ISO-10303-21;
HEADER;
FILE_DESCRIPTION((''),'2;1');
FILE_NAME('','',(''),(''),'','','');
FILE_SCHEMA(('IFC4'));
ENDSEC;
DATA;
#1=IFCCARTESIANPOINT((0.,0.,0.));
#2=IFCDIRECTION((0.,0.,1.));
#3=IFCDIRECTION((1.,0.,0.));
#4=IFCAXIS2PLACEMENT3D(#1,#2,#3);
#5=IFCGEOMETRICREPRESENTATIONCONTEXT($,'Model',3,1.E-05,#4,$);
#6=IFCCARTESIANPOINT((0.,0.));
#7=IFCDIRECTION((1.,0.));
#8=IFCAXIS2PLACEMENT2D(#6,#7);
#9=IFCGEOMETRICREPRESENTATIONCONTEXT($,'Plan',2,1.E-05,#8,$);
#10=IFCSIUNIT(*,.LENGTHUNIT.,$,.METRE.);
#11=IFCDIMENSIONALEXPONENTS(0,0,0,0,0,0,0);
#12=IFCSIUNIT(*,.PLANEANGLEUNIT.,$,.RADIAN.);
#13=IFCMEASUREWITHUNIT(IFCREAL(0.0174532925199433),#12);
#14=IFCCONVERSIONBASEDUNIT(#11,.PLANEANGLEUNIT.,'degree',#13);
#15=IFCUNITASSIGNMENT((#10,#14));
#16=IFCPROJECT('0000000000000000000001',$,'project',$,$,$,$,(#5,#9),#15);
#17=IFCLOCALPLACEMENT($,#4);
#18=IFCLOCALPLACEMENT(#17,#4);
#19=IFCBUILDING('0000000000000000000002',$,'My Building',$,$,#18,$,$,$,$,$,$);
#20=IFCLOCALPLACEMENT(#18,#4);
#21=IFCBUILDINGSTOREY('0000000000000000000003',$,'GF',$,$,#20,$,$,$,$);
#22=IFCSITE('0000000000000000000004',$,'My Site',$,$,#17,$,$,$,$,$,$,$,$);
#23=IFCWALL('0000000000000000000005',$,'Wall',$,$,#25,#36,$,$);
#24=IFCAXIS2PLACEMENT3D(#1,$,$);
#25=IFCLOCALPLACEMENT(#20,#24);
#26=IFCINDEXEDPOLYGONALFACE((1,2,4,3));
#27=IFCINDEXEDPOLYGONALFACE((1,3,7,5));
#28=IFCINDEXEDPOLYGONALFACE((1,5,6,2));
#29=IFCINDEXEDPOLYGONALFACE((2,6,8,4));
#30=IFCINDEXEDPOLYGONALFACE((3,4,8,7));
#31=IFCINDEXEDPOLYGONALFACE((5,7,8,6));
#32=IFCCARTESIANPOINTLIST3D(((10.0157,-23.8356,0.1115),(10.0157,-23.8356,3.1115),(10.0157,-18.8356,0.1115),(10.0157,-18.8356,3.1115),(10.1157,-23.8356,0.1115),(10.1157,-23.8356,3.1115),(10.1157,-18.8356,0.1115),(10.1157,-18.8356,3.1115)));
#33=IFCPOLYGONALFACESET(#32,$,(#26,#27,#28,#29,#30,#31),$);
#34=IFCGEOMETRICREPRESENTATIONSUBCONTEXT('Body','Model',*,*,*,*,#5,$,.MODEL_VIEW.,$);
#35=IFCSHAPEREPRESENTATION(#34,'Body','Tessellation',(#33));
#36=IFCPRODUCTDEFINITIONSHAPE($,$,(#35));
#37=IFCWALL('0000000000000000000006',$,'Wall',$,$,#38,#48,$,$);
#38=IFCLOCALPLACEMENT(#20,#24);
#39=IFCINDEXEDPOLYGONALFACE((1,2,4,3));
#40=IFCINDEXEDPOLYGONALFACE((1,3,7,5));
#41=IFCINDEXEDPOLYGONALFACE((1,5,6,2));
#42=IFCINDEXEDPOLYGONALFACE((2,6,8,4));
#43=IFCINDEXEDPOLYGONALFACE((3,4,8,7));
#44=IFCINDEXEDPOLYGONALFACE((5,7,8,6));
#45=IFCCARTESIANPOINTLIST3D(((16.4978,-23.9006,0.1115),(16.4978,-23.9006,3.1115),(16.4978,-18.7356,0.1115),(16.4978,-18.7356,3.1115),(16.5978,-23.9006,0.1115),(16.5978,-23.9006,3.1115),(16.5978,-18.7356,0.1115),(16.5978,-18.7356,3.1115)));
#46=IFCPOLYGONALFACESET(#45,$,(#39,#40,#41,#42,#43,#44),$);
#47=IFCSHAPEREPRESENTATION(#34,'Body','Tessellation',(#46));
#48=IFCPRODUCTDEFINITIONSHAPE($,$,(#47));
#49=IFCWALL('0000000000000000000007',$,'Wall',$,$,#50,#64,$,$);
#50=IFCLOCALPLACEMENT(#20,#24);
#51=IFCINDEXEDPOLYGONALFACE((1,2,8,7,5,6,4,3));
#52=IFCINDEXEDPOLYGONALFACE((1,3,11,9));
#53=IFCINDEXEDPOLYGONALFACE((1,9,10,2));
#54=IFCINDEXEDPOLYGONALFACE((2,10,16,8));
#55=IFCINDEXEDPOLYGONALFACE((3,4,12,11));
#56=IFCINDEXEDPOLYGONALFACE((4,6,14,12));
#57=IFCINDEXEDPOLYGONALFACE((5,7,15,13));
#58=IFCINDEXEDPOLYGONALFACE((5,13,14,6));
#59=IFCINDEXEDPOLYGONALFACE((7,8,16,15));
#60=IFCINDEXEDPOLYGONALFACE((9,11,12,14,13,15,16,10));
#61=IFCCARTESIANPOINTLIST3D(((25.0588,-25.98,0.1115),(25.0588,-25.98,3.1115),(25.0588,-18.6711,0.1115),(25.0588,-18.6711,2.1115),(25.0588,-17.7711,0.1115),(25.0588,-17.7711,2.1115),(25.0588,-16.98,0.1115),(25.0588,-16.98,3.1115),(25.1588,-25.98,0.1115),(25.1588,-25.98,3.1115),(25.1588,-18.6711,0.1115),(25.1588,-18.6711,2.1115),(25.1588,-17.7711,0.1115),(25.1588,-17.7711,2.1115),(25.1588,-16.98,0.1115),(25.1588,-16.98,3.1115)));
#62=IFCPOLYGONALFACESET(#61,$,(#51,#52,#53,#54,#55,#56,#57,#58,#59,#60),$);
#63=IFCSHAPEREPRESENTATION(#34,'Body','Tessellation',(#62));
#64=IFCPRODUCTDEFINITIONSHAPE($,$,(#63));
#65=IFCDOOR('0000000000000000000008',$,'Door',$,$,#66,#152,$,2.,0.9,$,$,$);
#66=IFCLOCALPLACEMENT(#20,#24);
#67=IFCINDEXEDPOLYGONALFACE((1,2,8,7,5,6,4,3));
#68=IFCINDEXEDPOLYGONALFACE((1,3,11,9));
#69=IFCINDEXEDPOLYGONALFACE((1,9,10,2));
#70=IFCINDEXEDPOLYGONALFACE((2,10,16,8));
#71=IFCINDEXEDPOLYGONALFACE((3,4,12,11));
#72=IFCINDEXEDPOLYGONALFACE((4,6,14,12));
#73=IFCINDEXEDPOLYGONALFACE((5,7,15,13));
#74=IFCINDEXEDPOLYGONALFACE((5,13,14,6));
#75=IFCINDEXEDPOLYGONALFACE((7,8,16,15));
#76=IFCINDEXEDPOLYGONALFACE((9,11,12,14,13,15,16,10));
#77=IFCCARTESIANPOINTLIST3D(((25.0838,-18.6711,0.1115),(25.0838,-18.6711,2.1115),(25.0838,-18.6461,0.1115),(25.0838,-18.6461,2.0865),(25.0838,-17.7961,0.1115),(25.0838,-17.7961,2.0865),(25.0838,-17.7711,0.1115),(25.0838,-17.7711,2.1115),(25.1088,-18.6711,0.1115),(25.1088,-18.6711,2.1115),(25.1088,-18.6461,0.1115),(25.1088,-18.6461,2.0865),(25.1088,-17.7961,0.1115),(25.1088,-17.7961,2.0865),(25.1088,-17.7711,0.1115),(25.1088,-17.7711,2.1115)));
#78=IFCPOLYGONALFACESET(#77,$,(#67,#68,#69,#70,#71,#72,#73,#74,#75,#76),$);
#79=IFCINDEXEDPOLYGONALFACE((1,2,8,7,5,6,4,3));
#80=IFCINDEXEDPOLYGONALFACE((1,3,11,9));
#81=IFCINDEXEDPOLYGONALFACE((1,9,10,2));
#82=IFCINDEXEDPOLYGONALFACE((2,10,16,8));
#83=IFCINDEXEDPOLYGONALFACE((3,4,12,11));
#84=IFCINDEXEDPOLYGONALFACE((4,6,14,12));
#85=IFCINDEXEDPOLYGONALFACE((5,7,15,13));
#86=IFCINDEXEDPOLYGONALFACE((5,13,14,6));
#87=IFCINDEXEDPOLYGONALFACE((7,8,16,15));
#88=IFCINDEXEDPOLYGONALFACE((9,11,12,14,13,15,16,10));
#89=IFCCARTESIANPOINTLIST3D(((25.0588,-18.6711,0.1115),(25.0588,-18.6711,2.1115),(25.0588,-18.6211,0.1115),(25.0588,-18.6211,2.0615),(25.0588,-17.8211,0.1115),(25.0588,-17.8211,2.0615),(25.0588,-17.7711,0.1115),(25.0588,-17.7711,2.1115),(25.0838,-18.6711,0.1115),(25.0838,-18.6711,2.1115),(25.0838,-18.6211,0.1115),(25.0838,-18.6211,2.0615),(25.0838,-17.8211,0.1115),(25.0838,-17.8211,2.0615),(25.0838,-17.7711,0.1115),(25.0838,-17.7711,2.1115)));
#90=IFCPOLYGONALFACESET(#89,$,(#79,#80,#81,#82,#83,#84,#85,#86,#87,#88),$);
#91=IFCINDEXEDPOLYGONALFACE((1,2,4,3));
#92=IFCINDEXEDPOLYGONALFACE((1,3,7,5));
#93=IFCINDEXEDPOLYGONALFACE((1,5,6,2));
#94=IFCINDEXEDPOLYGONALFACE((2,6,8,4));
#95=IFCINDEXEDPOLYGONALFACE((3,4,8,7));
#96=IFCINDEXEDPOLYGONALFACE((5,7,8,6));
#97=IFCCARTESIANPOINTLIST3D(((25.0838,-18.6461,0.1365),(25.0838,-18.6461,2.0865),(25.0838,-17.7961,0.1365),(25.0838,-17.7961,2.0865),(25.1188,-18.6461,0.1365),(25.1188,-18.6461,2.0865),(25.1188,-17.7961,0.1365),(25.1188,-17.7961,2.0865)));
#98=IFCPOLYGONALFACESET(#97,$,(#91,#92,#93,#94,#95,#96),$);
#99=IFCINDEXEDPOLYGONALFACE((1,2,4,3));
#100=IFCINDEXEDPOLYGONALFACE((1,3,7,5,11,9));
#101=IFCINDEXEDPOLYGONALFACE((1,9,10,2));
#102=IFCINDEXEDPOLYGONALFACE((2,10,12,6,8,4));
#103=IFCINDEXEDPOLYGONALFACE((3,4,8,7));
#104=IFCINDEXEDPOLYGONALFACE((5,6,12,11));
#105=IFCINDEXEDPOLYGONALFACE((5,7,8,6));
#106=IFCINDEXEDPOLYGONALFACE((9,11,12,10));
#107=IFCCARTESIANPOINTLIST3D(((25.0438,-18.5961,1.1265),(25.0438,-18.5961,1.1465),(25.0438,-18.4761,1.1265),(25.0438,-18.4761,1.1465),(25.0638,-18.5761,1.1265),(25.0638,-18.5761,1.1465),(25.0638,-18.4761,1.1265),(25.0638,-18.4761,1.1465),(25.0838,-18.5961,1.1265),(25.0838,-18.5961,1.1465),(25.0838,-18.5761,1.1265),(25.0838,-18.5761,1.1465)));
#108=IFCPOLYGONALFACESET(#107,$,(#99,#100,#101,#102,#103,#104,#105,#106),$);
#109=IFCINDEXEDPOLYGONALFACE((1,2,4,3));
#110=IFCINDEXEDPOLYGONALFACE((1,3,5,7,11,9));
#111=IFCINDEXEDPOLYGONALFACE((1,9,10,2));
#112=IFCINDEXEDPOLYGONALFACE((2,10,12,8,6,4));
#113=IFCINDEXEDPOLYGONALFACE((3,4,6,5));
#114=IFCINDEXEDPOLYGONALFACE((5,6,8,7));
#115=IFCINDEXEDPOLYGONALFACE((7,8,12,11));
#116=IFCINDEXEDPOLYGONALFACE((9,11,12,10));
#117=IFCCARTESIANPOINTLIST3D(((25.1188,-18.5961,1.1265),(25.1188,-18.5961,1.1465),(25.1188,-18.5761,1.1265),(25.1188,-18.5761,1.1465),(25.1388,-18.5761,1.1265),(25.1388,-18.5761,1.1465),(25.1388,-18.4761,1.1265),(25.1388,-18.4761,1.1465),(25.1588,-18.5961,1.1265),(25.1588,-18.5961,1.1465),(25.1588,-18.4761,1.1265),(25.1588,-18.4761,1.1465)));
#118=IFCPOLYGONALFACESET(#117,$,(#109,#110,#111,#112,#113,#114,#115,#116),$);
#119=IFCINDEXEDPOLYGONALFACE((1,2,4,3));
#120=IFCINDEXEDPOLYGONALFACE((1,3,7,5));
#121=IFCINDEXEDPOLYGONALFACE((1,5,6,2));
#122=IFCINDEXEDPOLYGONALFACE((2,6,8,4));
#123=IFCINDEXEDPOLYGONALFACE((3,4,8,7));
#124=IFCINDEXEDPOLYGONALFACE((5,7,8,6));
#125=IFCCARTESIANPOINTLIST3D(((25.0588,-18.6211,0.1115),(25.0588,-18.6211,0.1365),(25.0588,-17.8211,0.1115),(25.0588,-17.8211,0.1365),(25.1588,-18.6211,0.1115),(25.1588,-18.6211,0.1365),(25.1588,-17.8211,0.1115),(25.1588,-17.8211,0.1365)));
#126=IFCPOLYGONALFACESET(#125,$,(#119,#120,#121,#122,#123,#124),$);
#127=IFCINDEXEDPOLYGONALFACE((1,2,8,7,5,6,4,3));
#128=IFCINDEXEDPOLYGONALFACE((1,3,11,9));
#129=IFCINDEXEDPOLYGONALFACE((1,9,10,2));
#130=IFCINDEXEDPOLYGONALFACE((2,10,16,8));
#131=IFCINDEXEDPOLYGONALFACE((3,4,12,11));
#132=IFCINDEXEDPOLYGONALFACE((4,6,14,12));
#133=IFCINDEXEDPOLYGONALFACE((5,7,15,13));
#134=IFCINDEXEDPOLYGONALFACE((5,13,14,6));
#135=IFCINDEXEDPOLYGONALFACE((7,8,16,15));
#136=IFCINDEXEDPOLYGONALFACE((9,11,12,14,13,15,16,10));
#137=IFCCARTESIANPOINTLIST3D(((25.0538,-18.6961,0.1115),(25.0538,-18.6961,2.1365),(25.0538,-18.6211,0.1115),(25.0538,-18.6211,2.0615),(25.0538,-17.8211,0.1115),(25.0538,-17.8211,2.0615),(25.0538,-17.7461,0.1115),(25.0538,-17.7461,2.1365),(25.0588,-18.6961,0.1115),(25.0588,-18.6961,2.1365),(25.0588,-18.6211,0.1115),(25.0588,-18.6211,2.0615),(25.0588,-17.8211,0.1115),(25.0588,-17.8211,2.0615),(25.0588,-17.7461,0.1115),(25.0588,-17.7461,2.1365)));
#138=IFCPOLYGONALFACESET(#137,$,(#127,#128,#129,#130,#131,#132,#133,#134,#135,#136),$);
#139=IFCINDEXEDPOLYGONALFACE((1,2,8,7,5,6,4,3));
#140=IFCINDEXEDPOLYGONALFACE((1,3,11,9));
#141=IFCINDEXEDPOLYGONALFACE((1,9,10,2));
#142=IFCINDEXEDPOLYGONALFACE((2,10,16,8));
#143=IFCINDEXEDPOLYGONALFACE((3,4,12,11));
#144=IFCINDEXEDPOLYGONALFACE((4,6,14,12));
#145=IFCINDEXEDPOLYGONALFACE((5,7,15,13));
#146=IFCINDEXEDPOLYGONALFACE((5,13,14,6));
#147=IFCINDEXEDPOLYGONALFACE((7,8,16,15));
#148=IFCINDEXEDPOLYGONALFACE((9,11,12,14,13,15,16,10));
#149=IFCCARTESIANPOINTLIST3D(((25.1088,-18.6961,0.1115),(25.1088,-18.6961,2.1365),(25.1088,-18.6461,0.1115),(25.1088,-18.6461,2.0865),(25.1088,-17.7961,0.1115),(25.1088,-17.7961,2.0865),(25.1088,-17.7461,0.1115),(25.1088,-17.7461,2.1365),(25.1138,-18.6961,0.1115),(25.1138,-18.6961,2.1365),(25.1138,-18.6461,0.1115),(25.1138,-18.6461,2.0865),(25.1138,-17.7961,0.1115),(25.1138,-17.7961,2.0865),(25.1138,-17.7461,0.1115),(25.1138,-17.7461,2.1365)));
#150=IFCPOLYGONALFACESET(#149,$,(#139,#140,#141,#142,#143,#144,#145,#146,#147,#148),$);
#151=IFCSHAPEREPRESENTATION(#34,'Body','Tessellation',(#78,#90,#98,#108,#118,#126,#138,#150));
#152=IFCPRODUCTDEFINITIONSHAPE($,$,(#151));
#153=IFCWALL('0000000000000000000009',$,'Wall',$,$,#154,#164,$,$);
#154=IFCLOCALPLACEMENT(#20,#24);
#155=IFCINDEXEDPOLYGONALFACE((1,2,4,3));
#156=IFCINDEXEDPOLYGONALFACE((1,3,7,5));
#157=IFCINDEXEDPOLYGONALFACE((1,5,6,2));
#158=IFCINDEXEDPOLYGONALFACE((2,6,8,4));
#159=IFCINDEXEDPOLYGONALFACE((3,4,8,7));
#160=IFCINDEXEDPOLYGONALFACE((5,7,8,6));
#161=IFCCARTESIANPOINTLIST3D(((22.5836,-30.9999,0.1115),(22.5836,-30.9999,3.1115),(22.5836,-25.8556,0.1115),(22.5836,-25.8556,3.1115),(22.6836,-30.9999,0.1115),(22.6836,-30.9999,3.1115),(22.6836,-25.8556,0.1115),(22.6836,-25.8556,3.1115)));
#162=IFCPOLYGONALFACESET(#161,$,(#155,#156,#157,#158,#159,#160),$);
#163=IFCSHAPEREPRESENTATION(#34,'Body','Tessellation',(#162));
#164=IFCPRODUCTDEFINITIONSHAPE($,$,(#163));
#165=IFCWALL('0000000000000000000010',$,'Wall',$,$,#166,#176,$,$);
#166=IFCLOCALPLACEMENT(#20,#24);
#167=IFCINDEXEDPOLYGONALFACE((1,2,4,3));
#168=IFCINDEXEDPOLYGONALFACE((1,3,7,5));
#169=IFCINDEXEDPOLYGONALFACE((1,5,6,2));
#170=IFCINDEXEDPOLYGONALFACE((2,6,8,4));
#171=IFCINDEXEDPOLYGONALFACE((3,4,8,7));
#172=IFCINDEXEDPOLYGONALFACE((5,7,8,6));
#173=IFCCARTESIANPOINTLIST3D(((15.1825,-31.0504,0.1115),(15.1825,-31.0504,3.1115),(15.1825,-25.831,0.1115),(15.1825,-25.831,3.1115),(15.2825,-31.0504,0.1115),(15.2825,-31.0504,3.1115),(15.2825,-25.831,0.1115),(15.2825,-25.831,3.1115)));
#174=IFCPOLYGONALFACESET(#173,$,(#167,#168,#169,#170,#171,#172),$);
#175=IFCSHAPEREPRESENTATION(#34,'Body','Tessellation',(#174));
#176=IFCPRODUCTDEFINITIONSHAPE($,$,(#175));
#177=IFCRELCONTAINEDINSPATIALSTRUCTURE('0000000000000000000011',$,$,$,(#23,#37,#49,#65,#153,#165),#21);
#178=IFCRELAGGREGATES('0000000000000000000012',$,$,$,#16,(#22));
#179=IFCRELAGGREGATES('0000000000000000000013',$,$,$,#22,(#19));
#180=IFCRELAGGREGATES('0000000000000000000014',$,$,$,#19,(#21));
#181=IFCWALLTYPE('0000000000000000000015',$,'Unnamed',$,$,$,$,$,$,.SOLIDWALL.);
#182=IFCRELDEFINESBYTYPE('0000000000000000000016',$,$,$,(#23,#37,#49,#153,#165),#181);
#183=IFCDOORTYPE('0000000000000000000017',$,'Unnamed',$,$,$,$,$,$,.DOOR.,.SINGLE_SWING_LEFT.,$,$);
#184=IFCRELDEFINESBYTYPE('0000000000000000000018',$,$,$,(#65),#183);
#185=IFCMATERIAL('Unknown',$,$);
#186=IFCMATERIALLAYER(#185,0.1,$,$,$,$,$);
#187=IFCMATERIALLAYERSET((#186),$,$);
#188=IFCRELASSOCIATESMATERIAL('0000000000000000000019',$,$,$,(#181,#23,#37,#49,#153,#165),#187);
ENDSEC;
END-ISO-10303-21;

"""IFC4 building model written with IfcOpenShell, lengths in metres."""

from ifc_helpers import new_model, entity, si_unit, converted_unit, frame, origin_with_axes, origin_2d_with_axis, place, context, subcontext, project, spatial, line, indexed_curve, outline, extrude, shape, source, transform, mapped, material, layer, layer_set, layer_usage, type_object, type_shapes, element, fill, save


model = new_model("IFC4")

# Units and contexts
model_context = context("Model", 3, precision=1e-05, world=origin_with_axes())
plan_context = context("Plan", 2, precision=1e-05, world=origin_2d_with_axis())
body_context_1 = subcontext(model_context, "Body", "Model", "MODEL_VIEW")
body_context_2 = subcontext(plan_context, "Body", "Plan", "PLAN_VIEW")
ifc_project = project(units=[si_unit("LENGTHUNIT", "METRE"), converted_unit("PLANEANGLEUNIT", "degree", entity("IfcReal", 0.0174532925199433), si_unit("PLANEANGLEUNIT", "RADIAN"), dimensions=[0, 0, 0, 0, 0, 0, 0])], contexts=[model_context, plan_context])

# Site, building, storey
site_placement = place(None, origin_with_axes())
site = spatial("IfcSite", under=ifc_project, at=site_placement, Name="My Site")
building_placement = place(site_placement, origin_with_axes())
building = spatial("IfcBuilding", under=site, at=building_placement, Name="My Building")
storey_placement = place(building_placement, origin_with_axes())
storey = spatial("IfcBuildingStorey", under=building, at=storey_placement, Name="GF")

# Shared definitions
ifc_material = material(Name="Unknown")
ifc_layer = layer(ifc_material, 0.1)
ifc_layer_set = layer_set([ifc_layer])
wall_type = type_object("IfcWallType", Name="Unnamed", PredefinedType="SOLIDWALL", material=ifc_layer_set)

# Shared definitions
shared_shape_1 = source(origin_with_axes(), body_context_1, "Body", "SweptSolid", [
    extrude(outline(indexed_curve([(0.0, 0.0), (0.9, 0.0), (0.9, 2.0), (0.0, 2.0)], segments=[line(1, 2, 3, 4, 1)])), frame((0.0, -0.6, 0.0), z_axis=(0.0, -1.0, 0.0), x_axis=(1.0, 0.0, 0.0)), (0.0, 0.0, -1.0), 1.2),
])
door_type = type_object("IfcDoorType", Name="Unnamed", OperationType="SINGLE_SWING_LEFT", PredefinedType="DOOR")
shared_shape_2 = source(origin_with_axes(), body_context_1, "Body", "SweptSolid", [
    extrude(outline(indexed_curve([(0.0, 0.0), (0.0, 2.0), (0.9, 2.0), (0.9, 0.0), (0.875, 0.0), (0.875, 1.975), (0.025, 1.975), (0.025, 0.0)], segments=[line(1, 2, 3, 4, 5, 6, 7, 8, 1)])), frame((0.0, 0.025, 0.0), z_axis=(0.0, -1.0, 0.0), x_axis=(1.0, 0.0, 0.0)), (0.0, 0.0, -1.0), 0.025),
    extrude(outline(indexed_curve([(0.0, 0.0), (0.0, 2.0), (0.9, 2.0), (0.9, 0.0), (0.85, 0.0), (0.85, 1.95), (0.05, 1.95), (0.05, 0.0)], segments=[line(1, 2, 3, 4, 5, 6, 7, 8, 1)])), frame((0.0, 0.0, 0.0), z_axis=(0.0, -1.0, 0.0), x_axis=(1.0, 0.0, 0.0)), (0.0, 0.0, -1.0), 0.025),
    extrude(outline(indexed_curve([(0.0, 0.0), (0.85, 0.0), (0.85, 0.035), (0.0, 0.035)], segments=[line(1, 2, 3, 4, 1)])), frame((0.025, 0.025, 0.025), z_axis=(0.0, 0.0, 1.0), x_axis=(1.0, 0.0, 0.0)), (0.0, 0.0, 1.0), 1.95),
    extrude(outline(indexed_curve([(0.0, 0.0), (0.0, -0.04), (-0.12, -0.04), (-0.12, -0.02), (-0.02, -0.02), (-0.02, 0.0)], segments=[line(1, 2, 3, 4, 5, 6, 1)])), frame((0.825, 0.025, 1.015), z_axis=(0.0, 0.0, 1.0), x_axis=(1.0, 0.0, 0.0)), (0.0, 0.0, 1.0), 0.02),
    extrude(outline(indexed_curve([(0.0, 0.0), (0.0, 0.04), (-0.12, 0.04), (-0.12, 0.02), (-0.02, 0.02), (-0.02, 0.0)], segments=[line(1, 2, 3, 4, 5, 6, 1)])), frame((0.825, 0.06, 1.015), z_axis=(0.0, 0.0, 1.0), x_axis=(1.0, 0.0, 0.0)), (0.0, 0.0, 1.0), 0.02),
    extrude(outline(indexed_curve([(0.0, 0.0), (0.8, 0.0), (0.8, 0.1), (0.0, 0.1)], segments=[line(1, 2, 3, 4, 1)])), frame((0.05, 0.0, 0.0), z_axis=(0.0, 0.0, 1.0), x_axis=(1.0, 0.0, 0.0)), (0.0, 0.0, 1.0), 0.025),
    extrude(outline(indexed_curve([(0.0, 0.0), (0.0, 2.025), (0.95, 2.025), (0.95, 0.0), (0.875, 0.0), (0.875, 1.95), (0.075, 1.95), (0.075, 0.0)], segments=[line(1, 2, 3, 4, 5, 6, 7, 8, 1)])), frame((-0.025, -0.005, 0.0), z_axis=(0.0, -1.0, 0.0), x_axis=(1.0, 0.0, 0.0)), (0.0, 0.0, -1.0), 0.005),
    extrude(outline(indexed_curve([(0.0, 0.0), (0.0, 2.025), (0.95, 2.025), (0.95, 0.0), (0.9, 0.0), (0.9, 1.975), (0.05, 1.975), (0.05, 0.0)], segments=[line(1, 2, 3, 4, 5, 6, 7, 8, 1)])), frame((-0.025, 0.05, 0.0), z_axis=(0.0, -1.0, 0.0), x_axis=(1.0, 0.0, 0.0)), (0.0, 0.0, -1.0), 0.005),
])
shared_shape_3 = source(origin_with_axes(), body_context_2, "Body", "Curve2D", [
    entity("IfcIndexedPolyCurve", entity("IfcCartesianPointList2D", [[0.0, 0.0], [0.0, 0.05], [0.025, 0.05], [0.025, 0.025], [0.05, 0.025], [0.05, 0.0]]), [entity("IfcLineIndex", [1, 2, 3, 4, 5, 6, 1])]),
    entity("IfcIndexedPolyCurve", entity("IfcCartesianPointList2D", [[0.9, 0.0], [0.9, 0.05], [0.875, 0.05], [0.875, 0.025], [0.85, 0.025], [0.85, 0.0]]), [entity("IfcLineIndex", [1, 2, 3, 4, 5, 6, 1])]),
    entity("IfcTrimmedCurve", entity("IfcEllipse", entity("IfcAxis2Placement2D", entity("IfcCartesianPoint", [0.06, 0.05]), entity("IfcDirection", [1.0, 0.0])), 0.815, 0.85), [entity("IfcCartesianPoint", [0.875, 0.05])], [entity("IfcCartesianPoint", [0.06, 0.9])], True, "CARTESIAN"),
    entity("IfcIndexedPolyCurve", entity("IfcCartesianPointList2D", [[0.025, 0.05], [0.06, 0.05], [0.06, 0.9], [0.025, 0.9]]), [entity("IfcLineIndex", [1, 2, 3, 4, 1])]),
])
type_shapes(door_type, [shared_shape_2, shared_shape_3])

# Walls
ifc_layer_usage_1 = layer_usage(ifc_layer_set, "AXIS2", "POSITIVE", 0.0)
wall_1_placement = place(storey_placement, frame((10.0157, -18.8356, 0.1115), z_axis=(0.0, 0.0, 1.0), x_axis=(0.0, -1.0, 0.0)))
element("IfcWall", 1, at=wall_1_placement, inside=storey, type_object=wall_type, material=ifc_layer_usage_1, Name="Wall", context=body_context_1, shape_type="SweptSolid", body=[
    extrude(outline(indexed_curve([(0.0, 0.0), (0.0, 0.1), (5.0, 0.1), (5.0, 0.0)], segments=[line(1, 2, 3, 4, 1)])), origin_with_axes(), (0.0, 0.0, 1.0), 3.0),
])
ifc_layer_usage_2 = layer_usage(ifc_layer_set, "AXIS2", "POSITIVE", 0.0)
wall_2_placement = place(storey_placement, frame((16.4978, -18.7356, 0.1115), z_axis=(0.0, 0.0, 1.0), x_axis=(0.0, -1.0, 0.0)))
element("IfcWall", 2, at=wall_2_placement, inside=storey, type_object=wall_type, material=ifc_layer_usage_2, Name="Wall", context=body_context_1, shape_type="SweptSolid", body=[
    extrude(outline(indexed_curve([(0.0, 0.0), (0.0, 0.1), (5.1651, 0.1), (5.1651, 0.0)], segments=[line(1, 2, 3, 4, 1)])), origin_with_axes(), (0.0, 0.0, 1.0), 3.0),
])

# Wall, opening, door
ifc_layer_usage_3 = layer_usage(ifc_layer_set, "AXIS2", "POSITIVE", 0.0)
wall_3_placement = place(storey_placement, frame((25.0588, -16.98, 0.1115), z_axis=(0.0, 0.0, 1.0), x_axis=(0.0, -1.0, 0.0)))
wall_3 = element("IfcWall", 3, at=wall_3_placement, inside=storey, type_object=wall_type, material=ifc_layer_usage_3, Name="Wall", context=body_context_1, shape_type="SweptSolid", body=[
    extrude(outline(indexed_curve([(0.0, 0.0), (0.0, 0.1), (9.0, 0.1), (9.0, 0.0)], segments=[line(1, 2, 3, 4, 1)])), origin_with_axes(), (0.0, 0.0, 1.0), 3.0),
])
opening_1_placement = place(wall_3_placement, frame((0.7911, 0.0, 0.0), z_axis=(0.0, 0.0, 1.0), x_axis=(1.0, 0.0, 0.0)))
opening_1 = element("IfcOpeningElement", 4, at=opening_1_placement, cuts=wall_3, PredefinedType="OPENING", context=body_context_1, shape_type="MappedRepresentation", body=[
    mapped(shared_shape_1, transform((0.0, 0.0, 0.0), x_axis=(1.0, 0.0, 0.0), y_axis=(0.0, 1.0, 0.0), z_axis=(0.0, 0.0, 1.0), scale=1.0)),
])
door_1_placement = place(opening_1_placement, frame((0.0, 0.0, 0.0), z_axis=(0.0, 0.0, 1.0), x_axis=(1.0, 0.0, 0.0)))
door_1 = element("IfcDoor", 5, at=door_1_placement, inside=storey, type_object=door_type, Name="Door", OverallHeight=2.0, OverallWidth=0.9, shapes=[
    shape(body_context_1, "Body", "MappedRepresentation", [mapped(shared_shape_2, transform((0.0, 0.0, 0.0), x_axis=(1.0, 0.0, 0.0), y_axis=(0.0, 1.0, 0.0), z_axis=(0.0, 0.0, 1.0), scale=1.0))]),
    shape(body_context_2, "Body", "MappedRepresentation", [mapped(shared_shape_3, transform((0.0, 0.0, 0.0), x_axis=(1.0, 0.0, 0.0), y_axis=(0.0, 1.0, 0.0), z_axis=(0.0, 0.0, 1.0), scale=1.0))]),
])
fill(opening_1, door_1)

# Walls
ifc_layer_usage_4 = layer_usage(ifc_layer_set, "AXIS2", "POSITIVE", 0.0)
wall_4_placement = place(storey_placement, frame((22.5836, -25.8556, 0.1115), z_axis=(0.0, 0.0, 1.0), x_axis=(0.0, -1.0, 0.0)))
element("IfcWall", 6, at=wall_4_placement, inside=storey, type_object=wall_type, material=ifc_layer_usage_4, Name="Wall", context=body_context_1, shape_type="SweptSolid", body=[
    extrude(outline(indexed_curve([(0.0, 0.0), (0.0, 0.1), (5.1443, 0.1), (5.1443, 0.0)], segments=[line(1, 2, 3, 4, 1)])), origin_with_axes(), (0.0, 0.0, 1.0), 3.0),
])
ifc_layer_usage_5 = layer_usage(ifc_layer_set, "AXIS2", "POSITIVE", 0.0)
wall_5_placement = place(storey_placement, frame((15.1825, -25.831, 0.1115), z_axis=(0.0, 0.0, 1.0), x_axis=(0.0, -1.0, 0.0)))
element("IfcWall", 7, at=wall_5_placement, inside=storey, type_object=wall_type, material=ifc_layer_usage_5, Name="Wall", context=body_context_1, shape_type="SweptSolid", body=[
    extrude(outline(indexed_curve([(0.0, 0.0), (0.0, 0.1), (5.2194, 0.1), (5.2194, 0.0)], segments=[line(1, 2, 3, 4, 1)])), origin_with_axes(), (0.0, 0.0, 1.0), 3.0),
])

save(model, "model.ifc")
